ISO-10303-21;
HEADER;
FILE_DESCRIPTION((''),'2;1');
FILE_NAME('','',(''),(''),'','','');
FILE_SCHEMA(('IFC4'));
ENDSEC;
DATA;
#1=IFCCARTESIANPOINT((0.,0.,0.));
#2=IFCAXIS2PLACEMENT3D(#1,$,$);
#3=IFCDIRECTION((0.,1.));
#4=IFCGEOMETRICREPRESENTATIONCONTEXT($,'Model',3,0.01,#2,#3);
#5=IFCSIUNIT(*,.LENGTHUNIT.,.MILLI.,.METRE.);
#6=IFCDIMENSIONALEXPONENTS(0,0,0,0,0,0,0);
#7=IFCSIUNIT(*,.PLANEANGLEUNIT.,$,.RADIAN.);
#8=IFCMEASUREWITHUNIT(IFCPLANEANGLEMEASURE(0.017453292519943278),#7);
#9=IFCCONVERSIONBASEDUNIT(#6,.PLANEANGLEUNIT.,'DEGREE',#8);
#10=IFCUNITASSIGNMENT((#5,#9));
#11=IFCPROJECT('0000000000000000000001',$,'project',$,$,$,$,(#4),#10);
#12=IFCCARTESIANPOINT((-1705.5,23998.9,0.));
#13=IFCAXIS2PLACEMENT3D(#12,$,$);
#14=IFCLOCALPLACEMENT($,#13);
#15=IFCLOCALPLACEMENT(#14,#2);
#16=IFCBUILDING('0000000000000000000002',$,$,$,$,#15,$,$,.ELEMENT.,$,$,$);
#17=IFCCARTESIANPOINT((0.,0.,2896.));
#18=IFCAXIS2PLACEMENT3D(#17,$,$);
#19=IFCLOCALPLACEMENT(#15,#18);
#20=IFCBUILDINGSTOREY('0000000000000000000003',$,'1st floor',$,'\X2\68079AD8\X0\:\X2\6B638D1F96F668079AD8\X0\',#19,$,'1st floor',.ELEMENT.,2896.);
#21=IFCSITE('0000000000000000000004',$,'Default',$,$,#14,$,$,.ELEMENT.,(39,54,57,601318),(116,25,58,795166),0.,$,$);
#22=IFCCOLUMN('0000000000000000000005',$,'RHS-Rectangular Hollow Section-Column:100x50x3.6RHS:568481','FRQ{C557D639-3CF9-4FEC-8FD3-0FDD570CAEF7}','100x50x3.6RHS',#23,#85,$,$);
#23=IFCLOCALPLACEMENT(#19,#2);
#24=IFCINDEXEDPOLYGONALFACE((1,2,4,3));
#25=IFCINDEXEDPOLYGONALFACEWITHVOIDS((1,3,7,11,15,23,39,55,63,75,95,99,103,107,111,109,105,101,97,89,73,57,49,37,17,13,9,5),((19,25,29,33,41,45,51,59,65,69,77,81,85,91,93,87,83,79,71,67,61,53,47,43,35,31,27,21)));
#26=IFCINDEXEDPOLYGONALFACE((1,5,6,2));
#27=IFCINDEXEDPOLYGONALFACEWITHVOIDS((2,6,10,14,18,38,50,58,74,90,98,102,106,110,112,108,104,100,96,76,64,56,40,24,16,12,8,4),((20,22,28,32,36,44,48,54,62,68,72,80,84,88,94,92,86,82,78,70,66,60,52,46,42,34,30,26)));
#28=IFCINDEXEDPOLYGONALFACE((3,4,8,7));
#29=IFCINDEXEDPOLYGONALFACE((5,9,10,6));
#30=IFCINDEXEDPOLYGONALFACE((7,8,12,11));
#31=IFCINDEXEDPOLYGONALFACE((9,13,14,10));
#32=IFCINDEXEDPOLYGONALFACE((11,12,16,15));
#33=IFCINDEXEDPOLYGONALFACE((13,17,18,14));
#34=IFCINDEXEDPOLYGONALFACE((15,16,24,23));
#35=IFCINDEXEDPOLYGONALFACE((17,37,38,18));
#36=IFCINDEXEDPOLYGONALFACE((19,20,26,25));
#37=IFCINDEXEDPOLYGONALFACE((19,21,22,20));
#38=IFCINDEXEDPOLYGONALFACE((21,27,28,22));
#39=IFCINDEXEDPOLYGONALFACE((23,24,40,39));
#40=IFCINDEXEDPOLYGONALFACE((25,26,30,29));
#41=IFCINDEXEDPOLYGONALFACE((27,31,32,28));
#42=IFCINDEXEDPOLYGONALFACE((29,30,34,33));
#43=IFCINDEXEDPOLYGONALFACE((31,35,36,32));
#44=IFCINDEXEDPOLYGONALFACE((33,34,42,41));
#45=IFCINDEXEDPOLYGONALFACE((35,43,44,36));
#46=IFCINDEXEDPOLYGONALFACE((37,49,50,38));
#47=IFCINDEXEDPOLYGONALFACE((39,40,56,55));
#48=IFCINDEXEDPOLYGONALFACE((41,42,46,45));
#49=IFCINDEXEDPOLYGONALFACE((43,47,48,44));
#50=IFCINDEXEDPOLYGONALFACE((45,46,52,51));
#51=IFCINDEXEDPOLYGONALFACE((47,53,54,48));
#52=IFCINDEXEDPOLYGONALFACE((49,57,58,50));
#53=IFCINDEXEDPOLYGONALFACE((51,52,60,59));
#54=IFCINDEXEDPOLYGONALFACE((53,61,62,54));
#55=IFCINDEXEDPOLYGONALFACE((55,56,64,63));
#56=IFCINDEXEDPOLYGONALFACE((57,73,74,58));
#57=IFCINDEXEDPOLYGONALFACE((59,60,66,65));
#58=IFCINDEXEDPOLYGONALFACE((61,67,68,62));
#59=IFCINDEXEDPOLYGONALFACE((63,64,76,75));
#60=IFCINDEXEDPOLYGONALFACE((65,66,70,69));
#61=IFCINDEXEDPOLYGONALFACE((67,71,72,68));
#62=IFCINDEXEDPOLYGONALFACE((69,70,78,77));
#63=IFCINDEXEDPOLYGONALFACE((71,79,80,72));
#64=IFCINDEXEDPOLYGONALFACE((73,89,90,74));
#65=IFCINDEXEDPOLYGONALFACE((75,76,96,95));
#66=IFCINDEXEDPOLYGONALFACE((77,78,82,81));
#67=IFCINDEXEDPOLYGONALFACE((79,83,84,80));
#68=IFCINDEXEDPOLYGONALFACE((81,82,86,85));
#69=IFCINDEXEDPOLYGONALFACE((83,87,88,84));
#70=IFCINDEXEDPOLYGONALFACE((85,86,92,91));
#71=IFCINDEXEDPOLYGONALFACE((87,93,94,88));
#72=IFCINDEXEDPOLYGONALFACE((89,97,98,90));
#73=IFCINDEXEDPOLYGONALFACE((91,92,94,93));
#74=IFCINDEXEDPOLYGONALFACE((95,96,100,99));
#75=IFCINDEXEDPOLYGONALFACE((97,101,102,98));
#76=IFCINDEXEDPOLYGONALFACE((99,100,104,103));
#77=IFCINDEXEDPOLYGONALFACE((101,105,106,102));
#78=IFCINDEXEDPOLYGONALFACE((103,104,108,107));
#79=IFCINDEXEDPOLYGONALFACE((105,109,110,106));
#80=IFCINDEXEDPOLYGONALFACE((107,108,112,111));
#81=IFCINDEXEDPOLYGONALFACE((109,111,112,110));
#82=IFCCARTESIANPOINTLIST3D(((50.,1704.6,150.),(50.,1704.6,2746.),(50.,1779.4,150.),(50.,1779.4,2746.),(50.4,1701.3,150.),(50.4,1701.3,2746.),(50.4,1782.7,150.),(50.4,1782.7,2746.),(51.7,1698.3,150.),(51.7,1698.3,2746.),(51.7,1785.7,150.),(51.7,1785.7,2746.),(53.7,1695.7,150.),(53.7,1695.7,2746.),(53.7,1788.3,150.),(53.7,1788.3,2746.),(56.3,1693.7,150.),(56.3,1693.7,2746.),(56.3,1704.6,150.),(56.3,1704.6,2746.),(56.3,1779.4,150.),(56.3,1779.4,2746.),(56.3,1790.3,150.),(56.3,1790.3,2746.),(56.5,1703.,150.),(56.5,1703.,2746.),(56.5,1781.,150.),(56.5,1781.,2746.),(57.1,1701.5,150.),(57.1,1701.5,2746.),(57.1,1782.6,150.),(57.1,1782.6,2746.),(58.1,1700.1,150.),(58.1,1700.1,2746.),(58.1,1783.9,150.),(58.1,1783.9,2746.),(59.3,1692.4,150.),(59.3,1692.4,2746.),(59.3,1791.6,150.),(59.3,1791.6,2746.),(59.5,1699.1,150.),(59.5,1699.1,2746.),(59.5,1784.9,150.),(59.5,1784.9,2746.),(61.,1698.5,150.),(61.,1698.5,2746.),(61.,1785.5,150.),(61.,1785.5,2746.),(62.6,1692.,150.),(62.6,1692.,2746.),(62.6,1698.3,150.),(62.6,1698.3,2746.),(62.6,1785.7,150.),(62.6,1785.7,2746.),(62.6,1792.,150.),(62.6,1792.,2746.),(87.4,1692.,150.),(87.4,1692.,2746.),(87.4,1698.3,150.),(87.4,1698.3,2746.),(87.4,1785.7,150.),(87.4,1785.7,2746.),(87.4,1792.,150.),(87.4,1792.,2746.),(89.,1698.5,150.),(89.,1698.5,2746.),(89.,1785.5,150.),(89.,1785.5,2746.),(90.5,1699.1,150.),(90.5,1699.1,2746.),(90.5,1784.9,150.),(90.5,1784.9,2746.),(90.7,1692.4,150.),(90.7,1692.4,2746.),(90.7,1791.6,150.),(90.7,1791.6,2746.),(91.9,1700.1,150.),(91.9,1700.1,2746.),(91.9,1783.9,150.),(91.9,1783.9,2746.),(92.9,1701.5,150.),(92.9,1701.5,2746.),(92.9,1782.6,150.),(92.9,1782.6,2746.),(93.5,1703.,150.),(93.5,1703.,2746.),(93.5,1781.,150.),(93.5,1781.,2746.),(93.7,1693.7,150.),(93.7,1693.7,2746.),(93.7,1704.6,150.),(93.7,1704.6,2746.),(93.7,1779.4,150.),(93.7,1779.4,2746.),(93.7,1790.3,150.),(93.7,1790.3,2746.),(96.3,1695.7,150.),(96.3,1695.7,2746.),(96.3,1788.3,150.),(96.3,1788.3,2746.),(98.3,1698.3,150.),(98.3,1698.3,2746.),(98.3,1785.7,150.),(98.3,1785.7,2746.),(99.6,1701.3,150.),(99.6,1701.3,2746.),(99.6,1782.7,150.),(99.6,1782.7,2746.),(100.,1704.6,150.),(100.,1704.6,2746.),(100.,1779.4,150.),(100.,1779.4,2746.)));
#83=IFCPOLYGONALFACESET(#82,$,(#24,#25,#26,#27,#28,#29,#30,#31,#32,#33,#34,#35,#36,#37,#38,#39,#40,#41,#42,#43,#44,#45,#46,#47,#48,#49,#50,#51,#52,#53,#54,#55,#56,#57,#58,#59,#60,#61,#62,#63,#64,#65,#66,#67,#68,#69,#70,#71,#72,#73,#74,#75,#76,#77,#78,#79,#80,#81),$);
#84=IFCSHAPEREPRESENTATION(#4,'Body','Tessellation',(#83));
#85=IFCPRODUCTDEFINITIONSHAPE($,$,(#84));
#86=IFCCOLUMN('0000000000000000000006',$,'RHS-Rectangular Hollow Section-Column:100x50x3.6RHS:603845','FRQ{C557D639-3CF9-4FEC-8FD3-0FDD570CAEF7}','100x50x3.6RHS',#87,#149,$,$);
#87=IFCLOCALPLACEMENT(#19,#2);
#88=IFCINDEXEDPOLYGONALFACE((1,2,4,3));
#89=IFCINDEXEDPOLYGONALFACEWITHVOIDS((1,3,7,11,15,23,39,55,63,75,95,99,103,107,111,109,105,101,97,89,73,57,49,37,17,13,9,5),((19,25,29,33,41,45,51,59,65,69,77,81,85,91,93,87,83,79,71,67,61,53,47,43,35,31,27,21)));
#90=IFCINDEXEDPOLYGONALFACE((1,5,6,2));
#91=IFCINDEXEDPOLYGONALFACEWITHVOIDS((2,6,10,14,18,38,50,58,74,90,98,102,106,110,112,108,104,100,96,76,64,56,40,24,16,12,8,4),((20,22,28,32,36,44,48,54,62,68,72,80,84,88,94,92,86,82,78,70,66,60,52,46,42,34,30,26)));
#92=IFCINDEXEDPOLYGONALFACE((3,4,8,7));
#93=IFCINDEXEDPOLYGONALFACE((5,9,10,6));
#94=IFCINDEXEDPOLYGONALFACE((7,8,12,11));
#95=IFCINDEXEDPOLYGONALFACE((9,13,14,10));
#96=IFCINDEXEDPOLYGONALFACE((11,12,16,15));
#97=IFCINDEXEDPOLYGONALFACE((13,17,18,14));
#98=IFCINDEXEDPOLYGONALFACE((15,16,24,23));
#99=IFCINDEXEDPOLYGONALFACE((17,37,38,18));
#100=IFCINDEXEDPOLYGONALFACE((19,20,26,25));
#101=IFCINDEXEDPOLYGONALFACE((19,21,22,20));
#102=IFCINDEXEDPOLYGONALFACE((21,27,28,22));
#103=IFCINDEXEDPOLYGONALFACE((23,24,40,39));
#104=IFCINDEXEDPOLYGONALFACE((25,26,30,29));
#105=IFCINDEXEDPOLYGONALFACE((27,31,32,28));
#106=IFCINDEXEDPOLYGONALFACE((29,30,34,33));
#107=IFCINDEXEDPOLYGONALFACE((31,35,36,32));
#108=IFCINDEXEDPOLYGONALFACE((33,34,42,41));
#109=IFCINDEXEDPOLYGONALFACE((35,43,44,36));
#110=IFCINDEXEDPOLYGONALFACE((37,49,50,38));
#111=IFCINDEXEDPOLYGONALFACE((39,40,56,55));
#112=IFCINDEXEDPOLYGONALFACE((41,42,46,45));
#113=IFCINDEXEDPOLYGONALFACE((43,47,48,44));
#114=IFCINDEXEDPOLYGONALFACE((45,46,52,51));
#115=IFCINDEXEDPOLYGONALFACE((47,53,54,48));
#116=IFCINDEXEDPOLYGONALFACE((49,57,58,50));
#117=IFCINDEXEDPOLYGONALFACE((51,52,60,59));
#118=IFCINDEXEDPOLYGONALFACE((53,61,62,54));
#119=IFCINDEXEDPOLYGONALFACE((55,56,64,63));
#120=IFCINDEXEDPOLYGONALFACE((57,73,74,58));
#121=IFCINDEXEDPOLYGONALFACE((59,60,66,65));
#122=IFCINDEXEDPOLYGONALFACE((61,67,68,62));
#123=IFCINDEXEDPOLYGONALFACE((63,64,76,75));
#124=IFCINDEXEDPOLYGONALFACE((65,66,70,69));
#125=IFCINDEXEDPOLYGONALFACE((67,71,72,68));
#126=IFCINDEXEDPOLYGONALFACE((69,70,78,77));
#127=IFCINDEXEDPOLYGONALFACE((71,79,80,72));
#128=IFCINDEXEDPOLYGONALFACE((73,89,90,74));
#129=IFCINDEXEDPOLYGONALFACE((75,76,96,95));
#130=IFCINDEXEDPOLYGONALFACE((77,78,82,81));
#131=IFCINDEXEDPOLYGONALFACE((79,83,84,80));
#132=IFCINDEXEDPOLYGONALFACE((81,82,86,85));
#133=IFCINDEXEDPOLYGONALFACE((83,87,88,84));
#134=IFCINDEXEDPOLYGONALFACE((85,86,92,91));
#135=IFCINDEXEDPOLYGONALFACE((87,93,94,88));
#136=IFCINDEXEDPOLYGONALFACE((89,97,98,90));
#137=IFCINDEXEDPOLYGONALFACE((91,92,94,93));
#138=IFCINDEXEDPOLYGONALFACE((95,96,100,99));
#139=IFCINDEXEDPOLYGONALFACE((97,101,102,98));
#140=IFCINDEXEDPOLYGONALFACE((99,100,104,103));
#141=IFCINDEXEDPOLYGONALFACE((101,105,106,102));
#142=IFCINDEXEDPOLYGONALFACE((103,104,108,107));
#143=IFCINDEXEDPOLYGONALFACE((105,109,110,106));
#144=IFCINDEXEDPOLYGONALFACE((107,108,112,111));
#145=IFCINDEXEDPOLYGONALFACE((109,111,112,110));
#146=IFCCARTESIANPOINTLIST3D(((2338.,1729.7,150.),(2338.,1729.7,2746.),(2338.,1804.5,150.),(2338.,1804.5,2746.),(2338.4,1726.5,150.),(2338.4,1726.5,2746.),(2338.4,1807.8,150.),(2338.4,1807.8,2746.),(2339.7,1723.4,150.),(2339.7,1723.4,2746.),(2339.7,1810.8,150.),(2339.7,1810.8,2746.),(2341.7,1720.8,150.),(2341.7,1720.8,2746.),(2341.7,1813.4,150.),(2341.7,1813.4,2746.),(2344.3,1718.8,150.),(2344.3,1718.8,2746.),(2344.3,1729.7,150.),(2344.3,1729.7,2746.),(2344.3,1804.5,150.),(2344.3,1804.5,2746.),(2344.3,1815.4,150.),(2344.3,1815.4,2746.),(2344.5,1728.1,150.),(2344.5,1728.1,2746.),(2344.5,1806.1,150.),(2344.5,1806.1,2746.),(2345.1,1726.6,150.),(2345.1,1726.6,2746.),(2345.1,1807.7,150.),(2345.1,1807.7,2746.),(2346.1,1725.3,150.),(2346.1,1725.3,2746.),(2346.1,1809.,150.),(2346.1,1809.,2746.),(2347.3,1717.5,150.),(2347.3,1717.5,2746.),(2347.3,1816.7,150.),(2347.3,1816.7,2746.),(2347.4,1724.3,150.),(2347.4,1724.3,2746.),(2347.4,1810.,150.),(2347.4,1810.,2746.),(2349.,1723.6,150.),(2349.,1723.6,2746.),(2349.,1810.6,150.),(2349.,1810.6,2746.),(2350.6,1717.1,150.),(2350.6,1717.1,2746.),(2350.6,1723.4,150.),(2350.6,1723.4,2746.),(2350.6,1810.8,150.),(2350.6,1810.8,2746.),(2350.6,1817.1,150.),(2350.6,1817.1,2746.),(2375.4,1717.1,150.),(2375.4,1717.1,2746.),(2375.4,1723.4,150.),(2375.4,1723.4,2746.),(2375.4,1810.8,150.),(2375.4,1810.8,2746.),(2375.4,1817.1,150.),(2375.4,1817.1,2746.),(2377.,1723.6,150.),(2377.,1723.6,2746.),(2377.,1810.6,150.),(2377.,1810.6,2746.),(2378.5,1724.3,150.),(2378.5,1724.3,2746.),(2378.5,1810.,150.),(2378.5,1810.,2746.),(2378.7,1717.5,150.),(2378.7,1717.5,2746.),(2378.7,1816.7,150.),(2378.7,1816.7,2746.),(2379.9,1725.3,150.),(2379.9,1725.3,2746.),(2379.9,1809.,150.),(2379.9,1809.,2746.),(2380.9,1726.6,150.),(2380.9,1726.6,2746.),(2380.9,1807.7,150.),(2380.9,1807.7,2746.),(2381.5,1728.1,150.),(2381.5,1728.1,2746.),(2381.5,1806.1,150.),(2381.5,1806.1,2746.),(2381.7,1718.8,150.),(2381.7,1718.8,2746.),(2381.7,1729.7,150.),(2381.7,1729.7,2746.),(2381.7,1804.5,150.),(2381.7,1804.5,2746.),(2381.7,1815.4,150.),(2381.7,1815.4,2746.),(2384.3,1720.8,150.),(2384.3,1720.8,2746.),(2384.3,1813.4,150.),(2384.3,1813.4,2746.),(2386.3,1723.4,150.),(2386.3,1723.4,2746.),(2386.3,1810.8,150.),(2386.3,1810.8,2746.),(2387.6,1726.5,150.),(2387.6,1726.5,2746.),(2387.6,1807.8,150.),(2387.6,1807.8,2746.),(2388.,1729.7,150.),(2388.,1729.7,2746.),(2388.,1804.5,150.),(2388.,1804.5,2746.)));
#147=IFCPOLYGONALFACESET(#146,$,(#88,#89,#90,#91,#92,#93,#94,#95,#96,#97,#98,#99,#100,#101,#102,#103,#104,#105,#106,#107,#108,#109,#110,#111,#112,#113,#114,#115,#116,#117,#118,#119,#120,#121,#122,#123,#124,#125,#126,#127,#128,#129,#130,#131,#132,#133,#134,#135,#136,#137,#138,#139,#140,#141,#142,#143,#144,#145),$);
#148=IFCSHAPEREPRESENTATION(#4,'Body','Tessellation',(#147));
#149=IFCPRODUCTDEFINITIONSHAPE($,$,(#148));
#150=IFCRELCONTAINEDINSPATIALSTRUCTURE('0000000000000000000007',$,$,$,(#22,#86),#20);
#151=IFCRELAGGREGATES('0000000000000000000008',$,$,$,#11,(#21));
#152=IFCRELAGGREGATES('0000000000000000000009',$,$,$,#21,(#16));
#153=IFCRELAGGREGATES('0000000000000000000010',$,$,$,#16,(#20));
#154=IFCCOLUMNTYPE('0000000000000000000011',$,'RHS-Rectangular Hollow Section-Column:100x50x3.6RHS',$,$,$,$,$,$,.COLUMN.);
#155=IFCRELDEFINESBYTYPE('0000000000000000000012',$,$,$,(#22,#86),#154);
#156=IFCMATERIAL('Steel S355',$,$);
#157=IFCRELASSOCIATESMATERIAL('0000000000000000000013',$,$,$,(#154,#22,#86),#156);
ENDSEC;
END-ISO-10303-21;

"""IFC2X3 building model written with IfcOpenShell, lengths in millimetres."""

from ifc_helpers import new_model, entity, si_unit, converted_unit, point, direction, frame, frame_2d, origin, origin_2d, place, context, project, spatial, circle_curve, line_curve, trimmed, segment, composite_curve, hollow_rectangle, outline, extrude, clip, halfspace, material, type_object, element, save


model = new_model("IFC2X3")

# Units and contexts
model_context = context("Model", 3, precision=0.01, world=origin(), true_north=direction((0.0, 1.0)))
ifc_project = project(units=[si_unit("LENGTHUNIT", "METRE", prefix="MILLI"), converted_unit("PLANEANGLEUNIT", "DEGREE", entity("IfcPlaneAngleMeasure", 0.017453292519943278), si_unit("PLANEANGLEUNIT", "RADIAN"), dimensions=[0, 0, 0, 0, 0, 0, 0])], contexts=[model_context])

# Site, building, storey
site_placement = place(None, frame((-1705.5, 23998.9, 0.0)))
site = spatial("IfcSite", under=ifc_project, at=site_placement, Name="Default", CompositionType="ELEMENT", RefLatitude=(39, 54, 57, 601318), RefLongitude=(116, 25, 58, 795166), RefElevation=0.0)
building_placement = place(site_placement, origin())
building = spatial("IfcBuilding", under=site, at=building_placement, CompositionType="ELEMENT")
storey_placement = place(building_placement, frame((0.0, 0.0, 2896.0)))
storey = spatial("IfcBuildingStorey", under=building, at=storey_placement, Name="1st floor", ObjectType="标高:正负零标高", LongName="1st floor", CompositionType="ELEMENT", Elevation=2896.0)

# Column, opening
ifc_material_1 = material(Name="Steel S355")
column_type_1 = type_object("IfcColumnType", Name="RHS-Rectangular Hollow Section-Column:100x50x3.6RHS", PredefinedType="COLUMN", material=ifc_material_1)
column_1_placement = place(storey_placement, frame((75.0, 1742.0, 2876.9)))
column_1 = element("IfcColumn", 1, at=column_1_placement, inside=storey, type_object=column_type_1, material=ifc_material_1, Name="RHS-Rectangular Hollow Section-Column:100x50x3.6RHS:568481", Description="FRQ{C557D639-3CF9-4FEC-8FD3-0FDD570CAEF7}", ObjectType="100x50x3.6RHS", context=model_context, shape_type="Clipping", body=[
    clip(clip(extrude(hollow_rectangle(XDim=50.0, YDim=100.0, WallThickness=6.3, InnerFilletRadius=6.3, OuterFilletRadius=12.6, at=origin_2d()), origin(), (0.0, 0.0, -1.0), 2782.8), halfspace(frame((-75.0, -1742.0, -2726.9), z_axis=(0.0, 0.0, 1.0), x_axis=(1.0, 0.0, 0.0)), True)), halfspace(frame((-75.0, -1742.0, -55.9), z_axis=(0.0, 0.0, -1.0), x_axis=(-1.0, 0.0, 0.0)), True)),
])
opening_1_placement = place(column_1_placement, frame((0.0, -150.1, -130.9), z_axis=(0.0, 1.0, 0.0), x_axis=(-1.0, 0.0, 0.0)))
element("IfcOpeningElement", 2, at=opening_1_placement, cuts=column_1, ObjectType="Opening", context=model_context, shape_type="SweptSolid", body=[
    extrude(outline(composite_curve([segment(trimmed(circle_curve(frame_2d((43.0, 32.0), x_axis=(1.0, 0.0)), 32.0), [point((43.0, 0.0))], [point((75.0, 32.0))], True, "CARTESIAN"), True, "CONTINUOUS"), segment(trimmed(line_curve((75.0, 32.0), (0.0, 1.0), 86.0), [point((75.0, 32.0))], [point((75.0, 118.0))], True, "CARTESIAN"), True, "CONTINUOUS"), segment(trimmed(circle_curve(frame_2d((43.0, 118.0), x_axis=(1.0, 0.0)), 32.0), [point((75.0, 118.0))], [point((43.0, 150.0))], True, "CARTESIAN"), True, "CONTINUOUS"), segment(trimmed(line_curve((43.0, 150.0), (-1.0, 0.0), 86.0), [point((43.0, 150.0))], [point((-43.0, 150.0))], True, "CARTESIAN"), True, "CONTINUOUS"), segment(trimmed(circle_curve(frame_2d((-43.0, 118.0), x_axis=(1.0, 0.0)), 32.0), [point((-43.0, 150.0))], [point((-75.0, 118.0))], True, "CARTESIAN"), True, "CONTINUOUS"), segment(trimmed(line_curve((-75.0, 118.0), (0.0, -1.0), 86.0), [point((-75.0, 118.0))], [point((-75.0, 32.0))], True, "CARTESIAN"), True, "CONTINUOUS"), segment(trimmed(circle_curve(frame_2d((-43.0, 32.0), x_axis=(1.0, 0.0)), 32.0), [point((-75.0, 32.0))], [point((-43.0, 0.0))], True, "CARTESIAN"), True, "CONTINUOUS"), segment(trimmed(line_curve((-43.0, 0.0), (1.0, 0.0), 86.0), [point((-43.0, 0.0))], [point((43.0, 0.0))], True, "CARTESIAN"), True, "CONTINUOUS")], self_intersect="UNKNOWN")), origin(), (0.0, 0.0, 1.0), 300.2),
])

# Column
column_2_placement = place(storey_placement, frame((2363.0, 1767.1, 2746.0), z_axis=(0.0, 0.0, 1.0), x_axis=(-1.0, 0.0, 0.0)))
element("IfcColumn", 3, at=column_2_placement, inside=storey, type_object=column_type_1, material=ifc_material_1, Name="RHS-Rectangular Hollow Section-Column:100x50x3.6RHS:603845", Description="FRQ{C557D639-3CF9-4FEC-8FD3-0FDD570CAEF7}", ObjectType="100x50x3.6RHS", context=model_context, shape_type="Clipping", body=[
    clip(extrude(hollow_rectangle(XDim=50.0, YDim=100.0, WallThickness=6.3, InnerFilletRadius=6.3, OuterFilletRadius=12.6, at=origin_2d()), origin(), (0.0, 0.0, -1.0), 2651.9), halfspace(frame((2363.0, 1767.1, -2596.0), z_axis=(0.0, 0.0, 1.0), x_axis=(-1.0, 0.0, 0.0)), True)),
])

save(model, "model.ifc")
